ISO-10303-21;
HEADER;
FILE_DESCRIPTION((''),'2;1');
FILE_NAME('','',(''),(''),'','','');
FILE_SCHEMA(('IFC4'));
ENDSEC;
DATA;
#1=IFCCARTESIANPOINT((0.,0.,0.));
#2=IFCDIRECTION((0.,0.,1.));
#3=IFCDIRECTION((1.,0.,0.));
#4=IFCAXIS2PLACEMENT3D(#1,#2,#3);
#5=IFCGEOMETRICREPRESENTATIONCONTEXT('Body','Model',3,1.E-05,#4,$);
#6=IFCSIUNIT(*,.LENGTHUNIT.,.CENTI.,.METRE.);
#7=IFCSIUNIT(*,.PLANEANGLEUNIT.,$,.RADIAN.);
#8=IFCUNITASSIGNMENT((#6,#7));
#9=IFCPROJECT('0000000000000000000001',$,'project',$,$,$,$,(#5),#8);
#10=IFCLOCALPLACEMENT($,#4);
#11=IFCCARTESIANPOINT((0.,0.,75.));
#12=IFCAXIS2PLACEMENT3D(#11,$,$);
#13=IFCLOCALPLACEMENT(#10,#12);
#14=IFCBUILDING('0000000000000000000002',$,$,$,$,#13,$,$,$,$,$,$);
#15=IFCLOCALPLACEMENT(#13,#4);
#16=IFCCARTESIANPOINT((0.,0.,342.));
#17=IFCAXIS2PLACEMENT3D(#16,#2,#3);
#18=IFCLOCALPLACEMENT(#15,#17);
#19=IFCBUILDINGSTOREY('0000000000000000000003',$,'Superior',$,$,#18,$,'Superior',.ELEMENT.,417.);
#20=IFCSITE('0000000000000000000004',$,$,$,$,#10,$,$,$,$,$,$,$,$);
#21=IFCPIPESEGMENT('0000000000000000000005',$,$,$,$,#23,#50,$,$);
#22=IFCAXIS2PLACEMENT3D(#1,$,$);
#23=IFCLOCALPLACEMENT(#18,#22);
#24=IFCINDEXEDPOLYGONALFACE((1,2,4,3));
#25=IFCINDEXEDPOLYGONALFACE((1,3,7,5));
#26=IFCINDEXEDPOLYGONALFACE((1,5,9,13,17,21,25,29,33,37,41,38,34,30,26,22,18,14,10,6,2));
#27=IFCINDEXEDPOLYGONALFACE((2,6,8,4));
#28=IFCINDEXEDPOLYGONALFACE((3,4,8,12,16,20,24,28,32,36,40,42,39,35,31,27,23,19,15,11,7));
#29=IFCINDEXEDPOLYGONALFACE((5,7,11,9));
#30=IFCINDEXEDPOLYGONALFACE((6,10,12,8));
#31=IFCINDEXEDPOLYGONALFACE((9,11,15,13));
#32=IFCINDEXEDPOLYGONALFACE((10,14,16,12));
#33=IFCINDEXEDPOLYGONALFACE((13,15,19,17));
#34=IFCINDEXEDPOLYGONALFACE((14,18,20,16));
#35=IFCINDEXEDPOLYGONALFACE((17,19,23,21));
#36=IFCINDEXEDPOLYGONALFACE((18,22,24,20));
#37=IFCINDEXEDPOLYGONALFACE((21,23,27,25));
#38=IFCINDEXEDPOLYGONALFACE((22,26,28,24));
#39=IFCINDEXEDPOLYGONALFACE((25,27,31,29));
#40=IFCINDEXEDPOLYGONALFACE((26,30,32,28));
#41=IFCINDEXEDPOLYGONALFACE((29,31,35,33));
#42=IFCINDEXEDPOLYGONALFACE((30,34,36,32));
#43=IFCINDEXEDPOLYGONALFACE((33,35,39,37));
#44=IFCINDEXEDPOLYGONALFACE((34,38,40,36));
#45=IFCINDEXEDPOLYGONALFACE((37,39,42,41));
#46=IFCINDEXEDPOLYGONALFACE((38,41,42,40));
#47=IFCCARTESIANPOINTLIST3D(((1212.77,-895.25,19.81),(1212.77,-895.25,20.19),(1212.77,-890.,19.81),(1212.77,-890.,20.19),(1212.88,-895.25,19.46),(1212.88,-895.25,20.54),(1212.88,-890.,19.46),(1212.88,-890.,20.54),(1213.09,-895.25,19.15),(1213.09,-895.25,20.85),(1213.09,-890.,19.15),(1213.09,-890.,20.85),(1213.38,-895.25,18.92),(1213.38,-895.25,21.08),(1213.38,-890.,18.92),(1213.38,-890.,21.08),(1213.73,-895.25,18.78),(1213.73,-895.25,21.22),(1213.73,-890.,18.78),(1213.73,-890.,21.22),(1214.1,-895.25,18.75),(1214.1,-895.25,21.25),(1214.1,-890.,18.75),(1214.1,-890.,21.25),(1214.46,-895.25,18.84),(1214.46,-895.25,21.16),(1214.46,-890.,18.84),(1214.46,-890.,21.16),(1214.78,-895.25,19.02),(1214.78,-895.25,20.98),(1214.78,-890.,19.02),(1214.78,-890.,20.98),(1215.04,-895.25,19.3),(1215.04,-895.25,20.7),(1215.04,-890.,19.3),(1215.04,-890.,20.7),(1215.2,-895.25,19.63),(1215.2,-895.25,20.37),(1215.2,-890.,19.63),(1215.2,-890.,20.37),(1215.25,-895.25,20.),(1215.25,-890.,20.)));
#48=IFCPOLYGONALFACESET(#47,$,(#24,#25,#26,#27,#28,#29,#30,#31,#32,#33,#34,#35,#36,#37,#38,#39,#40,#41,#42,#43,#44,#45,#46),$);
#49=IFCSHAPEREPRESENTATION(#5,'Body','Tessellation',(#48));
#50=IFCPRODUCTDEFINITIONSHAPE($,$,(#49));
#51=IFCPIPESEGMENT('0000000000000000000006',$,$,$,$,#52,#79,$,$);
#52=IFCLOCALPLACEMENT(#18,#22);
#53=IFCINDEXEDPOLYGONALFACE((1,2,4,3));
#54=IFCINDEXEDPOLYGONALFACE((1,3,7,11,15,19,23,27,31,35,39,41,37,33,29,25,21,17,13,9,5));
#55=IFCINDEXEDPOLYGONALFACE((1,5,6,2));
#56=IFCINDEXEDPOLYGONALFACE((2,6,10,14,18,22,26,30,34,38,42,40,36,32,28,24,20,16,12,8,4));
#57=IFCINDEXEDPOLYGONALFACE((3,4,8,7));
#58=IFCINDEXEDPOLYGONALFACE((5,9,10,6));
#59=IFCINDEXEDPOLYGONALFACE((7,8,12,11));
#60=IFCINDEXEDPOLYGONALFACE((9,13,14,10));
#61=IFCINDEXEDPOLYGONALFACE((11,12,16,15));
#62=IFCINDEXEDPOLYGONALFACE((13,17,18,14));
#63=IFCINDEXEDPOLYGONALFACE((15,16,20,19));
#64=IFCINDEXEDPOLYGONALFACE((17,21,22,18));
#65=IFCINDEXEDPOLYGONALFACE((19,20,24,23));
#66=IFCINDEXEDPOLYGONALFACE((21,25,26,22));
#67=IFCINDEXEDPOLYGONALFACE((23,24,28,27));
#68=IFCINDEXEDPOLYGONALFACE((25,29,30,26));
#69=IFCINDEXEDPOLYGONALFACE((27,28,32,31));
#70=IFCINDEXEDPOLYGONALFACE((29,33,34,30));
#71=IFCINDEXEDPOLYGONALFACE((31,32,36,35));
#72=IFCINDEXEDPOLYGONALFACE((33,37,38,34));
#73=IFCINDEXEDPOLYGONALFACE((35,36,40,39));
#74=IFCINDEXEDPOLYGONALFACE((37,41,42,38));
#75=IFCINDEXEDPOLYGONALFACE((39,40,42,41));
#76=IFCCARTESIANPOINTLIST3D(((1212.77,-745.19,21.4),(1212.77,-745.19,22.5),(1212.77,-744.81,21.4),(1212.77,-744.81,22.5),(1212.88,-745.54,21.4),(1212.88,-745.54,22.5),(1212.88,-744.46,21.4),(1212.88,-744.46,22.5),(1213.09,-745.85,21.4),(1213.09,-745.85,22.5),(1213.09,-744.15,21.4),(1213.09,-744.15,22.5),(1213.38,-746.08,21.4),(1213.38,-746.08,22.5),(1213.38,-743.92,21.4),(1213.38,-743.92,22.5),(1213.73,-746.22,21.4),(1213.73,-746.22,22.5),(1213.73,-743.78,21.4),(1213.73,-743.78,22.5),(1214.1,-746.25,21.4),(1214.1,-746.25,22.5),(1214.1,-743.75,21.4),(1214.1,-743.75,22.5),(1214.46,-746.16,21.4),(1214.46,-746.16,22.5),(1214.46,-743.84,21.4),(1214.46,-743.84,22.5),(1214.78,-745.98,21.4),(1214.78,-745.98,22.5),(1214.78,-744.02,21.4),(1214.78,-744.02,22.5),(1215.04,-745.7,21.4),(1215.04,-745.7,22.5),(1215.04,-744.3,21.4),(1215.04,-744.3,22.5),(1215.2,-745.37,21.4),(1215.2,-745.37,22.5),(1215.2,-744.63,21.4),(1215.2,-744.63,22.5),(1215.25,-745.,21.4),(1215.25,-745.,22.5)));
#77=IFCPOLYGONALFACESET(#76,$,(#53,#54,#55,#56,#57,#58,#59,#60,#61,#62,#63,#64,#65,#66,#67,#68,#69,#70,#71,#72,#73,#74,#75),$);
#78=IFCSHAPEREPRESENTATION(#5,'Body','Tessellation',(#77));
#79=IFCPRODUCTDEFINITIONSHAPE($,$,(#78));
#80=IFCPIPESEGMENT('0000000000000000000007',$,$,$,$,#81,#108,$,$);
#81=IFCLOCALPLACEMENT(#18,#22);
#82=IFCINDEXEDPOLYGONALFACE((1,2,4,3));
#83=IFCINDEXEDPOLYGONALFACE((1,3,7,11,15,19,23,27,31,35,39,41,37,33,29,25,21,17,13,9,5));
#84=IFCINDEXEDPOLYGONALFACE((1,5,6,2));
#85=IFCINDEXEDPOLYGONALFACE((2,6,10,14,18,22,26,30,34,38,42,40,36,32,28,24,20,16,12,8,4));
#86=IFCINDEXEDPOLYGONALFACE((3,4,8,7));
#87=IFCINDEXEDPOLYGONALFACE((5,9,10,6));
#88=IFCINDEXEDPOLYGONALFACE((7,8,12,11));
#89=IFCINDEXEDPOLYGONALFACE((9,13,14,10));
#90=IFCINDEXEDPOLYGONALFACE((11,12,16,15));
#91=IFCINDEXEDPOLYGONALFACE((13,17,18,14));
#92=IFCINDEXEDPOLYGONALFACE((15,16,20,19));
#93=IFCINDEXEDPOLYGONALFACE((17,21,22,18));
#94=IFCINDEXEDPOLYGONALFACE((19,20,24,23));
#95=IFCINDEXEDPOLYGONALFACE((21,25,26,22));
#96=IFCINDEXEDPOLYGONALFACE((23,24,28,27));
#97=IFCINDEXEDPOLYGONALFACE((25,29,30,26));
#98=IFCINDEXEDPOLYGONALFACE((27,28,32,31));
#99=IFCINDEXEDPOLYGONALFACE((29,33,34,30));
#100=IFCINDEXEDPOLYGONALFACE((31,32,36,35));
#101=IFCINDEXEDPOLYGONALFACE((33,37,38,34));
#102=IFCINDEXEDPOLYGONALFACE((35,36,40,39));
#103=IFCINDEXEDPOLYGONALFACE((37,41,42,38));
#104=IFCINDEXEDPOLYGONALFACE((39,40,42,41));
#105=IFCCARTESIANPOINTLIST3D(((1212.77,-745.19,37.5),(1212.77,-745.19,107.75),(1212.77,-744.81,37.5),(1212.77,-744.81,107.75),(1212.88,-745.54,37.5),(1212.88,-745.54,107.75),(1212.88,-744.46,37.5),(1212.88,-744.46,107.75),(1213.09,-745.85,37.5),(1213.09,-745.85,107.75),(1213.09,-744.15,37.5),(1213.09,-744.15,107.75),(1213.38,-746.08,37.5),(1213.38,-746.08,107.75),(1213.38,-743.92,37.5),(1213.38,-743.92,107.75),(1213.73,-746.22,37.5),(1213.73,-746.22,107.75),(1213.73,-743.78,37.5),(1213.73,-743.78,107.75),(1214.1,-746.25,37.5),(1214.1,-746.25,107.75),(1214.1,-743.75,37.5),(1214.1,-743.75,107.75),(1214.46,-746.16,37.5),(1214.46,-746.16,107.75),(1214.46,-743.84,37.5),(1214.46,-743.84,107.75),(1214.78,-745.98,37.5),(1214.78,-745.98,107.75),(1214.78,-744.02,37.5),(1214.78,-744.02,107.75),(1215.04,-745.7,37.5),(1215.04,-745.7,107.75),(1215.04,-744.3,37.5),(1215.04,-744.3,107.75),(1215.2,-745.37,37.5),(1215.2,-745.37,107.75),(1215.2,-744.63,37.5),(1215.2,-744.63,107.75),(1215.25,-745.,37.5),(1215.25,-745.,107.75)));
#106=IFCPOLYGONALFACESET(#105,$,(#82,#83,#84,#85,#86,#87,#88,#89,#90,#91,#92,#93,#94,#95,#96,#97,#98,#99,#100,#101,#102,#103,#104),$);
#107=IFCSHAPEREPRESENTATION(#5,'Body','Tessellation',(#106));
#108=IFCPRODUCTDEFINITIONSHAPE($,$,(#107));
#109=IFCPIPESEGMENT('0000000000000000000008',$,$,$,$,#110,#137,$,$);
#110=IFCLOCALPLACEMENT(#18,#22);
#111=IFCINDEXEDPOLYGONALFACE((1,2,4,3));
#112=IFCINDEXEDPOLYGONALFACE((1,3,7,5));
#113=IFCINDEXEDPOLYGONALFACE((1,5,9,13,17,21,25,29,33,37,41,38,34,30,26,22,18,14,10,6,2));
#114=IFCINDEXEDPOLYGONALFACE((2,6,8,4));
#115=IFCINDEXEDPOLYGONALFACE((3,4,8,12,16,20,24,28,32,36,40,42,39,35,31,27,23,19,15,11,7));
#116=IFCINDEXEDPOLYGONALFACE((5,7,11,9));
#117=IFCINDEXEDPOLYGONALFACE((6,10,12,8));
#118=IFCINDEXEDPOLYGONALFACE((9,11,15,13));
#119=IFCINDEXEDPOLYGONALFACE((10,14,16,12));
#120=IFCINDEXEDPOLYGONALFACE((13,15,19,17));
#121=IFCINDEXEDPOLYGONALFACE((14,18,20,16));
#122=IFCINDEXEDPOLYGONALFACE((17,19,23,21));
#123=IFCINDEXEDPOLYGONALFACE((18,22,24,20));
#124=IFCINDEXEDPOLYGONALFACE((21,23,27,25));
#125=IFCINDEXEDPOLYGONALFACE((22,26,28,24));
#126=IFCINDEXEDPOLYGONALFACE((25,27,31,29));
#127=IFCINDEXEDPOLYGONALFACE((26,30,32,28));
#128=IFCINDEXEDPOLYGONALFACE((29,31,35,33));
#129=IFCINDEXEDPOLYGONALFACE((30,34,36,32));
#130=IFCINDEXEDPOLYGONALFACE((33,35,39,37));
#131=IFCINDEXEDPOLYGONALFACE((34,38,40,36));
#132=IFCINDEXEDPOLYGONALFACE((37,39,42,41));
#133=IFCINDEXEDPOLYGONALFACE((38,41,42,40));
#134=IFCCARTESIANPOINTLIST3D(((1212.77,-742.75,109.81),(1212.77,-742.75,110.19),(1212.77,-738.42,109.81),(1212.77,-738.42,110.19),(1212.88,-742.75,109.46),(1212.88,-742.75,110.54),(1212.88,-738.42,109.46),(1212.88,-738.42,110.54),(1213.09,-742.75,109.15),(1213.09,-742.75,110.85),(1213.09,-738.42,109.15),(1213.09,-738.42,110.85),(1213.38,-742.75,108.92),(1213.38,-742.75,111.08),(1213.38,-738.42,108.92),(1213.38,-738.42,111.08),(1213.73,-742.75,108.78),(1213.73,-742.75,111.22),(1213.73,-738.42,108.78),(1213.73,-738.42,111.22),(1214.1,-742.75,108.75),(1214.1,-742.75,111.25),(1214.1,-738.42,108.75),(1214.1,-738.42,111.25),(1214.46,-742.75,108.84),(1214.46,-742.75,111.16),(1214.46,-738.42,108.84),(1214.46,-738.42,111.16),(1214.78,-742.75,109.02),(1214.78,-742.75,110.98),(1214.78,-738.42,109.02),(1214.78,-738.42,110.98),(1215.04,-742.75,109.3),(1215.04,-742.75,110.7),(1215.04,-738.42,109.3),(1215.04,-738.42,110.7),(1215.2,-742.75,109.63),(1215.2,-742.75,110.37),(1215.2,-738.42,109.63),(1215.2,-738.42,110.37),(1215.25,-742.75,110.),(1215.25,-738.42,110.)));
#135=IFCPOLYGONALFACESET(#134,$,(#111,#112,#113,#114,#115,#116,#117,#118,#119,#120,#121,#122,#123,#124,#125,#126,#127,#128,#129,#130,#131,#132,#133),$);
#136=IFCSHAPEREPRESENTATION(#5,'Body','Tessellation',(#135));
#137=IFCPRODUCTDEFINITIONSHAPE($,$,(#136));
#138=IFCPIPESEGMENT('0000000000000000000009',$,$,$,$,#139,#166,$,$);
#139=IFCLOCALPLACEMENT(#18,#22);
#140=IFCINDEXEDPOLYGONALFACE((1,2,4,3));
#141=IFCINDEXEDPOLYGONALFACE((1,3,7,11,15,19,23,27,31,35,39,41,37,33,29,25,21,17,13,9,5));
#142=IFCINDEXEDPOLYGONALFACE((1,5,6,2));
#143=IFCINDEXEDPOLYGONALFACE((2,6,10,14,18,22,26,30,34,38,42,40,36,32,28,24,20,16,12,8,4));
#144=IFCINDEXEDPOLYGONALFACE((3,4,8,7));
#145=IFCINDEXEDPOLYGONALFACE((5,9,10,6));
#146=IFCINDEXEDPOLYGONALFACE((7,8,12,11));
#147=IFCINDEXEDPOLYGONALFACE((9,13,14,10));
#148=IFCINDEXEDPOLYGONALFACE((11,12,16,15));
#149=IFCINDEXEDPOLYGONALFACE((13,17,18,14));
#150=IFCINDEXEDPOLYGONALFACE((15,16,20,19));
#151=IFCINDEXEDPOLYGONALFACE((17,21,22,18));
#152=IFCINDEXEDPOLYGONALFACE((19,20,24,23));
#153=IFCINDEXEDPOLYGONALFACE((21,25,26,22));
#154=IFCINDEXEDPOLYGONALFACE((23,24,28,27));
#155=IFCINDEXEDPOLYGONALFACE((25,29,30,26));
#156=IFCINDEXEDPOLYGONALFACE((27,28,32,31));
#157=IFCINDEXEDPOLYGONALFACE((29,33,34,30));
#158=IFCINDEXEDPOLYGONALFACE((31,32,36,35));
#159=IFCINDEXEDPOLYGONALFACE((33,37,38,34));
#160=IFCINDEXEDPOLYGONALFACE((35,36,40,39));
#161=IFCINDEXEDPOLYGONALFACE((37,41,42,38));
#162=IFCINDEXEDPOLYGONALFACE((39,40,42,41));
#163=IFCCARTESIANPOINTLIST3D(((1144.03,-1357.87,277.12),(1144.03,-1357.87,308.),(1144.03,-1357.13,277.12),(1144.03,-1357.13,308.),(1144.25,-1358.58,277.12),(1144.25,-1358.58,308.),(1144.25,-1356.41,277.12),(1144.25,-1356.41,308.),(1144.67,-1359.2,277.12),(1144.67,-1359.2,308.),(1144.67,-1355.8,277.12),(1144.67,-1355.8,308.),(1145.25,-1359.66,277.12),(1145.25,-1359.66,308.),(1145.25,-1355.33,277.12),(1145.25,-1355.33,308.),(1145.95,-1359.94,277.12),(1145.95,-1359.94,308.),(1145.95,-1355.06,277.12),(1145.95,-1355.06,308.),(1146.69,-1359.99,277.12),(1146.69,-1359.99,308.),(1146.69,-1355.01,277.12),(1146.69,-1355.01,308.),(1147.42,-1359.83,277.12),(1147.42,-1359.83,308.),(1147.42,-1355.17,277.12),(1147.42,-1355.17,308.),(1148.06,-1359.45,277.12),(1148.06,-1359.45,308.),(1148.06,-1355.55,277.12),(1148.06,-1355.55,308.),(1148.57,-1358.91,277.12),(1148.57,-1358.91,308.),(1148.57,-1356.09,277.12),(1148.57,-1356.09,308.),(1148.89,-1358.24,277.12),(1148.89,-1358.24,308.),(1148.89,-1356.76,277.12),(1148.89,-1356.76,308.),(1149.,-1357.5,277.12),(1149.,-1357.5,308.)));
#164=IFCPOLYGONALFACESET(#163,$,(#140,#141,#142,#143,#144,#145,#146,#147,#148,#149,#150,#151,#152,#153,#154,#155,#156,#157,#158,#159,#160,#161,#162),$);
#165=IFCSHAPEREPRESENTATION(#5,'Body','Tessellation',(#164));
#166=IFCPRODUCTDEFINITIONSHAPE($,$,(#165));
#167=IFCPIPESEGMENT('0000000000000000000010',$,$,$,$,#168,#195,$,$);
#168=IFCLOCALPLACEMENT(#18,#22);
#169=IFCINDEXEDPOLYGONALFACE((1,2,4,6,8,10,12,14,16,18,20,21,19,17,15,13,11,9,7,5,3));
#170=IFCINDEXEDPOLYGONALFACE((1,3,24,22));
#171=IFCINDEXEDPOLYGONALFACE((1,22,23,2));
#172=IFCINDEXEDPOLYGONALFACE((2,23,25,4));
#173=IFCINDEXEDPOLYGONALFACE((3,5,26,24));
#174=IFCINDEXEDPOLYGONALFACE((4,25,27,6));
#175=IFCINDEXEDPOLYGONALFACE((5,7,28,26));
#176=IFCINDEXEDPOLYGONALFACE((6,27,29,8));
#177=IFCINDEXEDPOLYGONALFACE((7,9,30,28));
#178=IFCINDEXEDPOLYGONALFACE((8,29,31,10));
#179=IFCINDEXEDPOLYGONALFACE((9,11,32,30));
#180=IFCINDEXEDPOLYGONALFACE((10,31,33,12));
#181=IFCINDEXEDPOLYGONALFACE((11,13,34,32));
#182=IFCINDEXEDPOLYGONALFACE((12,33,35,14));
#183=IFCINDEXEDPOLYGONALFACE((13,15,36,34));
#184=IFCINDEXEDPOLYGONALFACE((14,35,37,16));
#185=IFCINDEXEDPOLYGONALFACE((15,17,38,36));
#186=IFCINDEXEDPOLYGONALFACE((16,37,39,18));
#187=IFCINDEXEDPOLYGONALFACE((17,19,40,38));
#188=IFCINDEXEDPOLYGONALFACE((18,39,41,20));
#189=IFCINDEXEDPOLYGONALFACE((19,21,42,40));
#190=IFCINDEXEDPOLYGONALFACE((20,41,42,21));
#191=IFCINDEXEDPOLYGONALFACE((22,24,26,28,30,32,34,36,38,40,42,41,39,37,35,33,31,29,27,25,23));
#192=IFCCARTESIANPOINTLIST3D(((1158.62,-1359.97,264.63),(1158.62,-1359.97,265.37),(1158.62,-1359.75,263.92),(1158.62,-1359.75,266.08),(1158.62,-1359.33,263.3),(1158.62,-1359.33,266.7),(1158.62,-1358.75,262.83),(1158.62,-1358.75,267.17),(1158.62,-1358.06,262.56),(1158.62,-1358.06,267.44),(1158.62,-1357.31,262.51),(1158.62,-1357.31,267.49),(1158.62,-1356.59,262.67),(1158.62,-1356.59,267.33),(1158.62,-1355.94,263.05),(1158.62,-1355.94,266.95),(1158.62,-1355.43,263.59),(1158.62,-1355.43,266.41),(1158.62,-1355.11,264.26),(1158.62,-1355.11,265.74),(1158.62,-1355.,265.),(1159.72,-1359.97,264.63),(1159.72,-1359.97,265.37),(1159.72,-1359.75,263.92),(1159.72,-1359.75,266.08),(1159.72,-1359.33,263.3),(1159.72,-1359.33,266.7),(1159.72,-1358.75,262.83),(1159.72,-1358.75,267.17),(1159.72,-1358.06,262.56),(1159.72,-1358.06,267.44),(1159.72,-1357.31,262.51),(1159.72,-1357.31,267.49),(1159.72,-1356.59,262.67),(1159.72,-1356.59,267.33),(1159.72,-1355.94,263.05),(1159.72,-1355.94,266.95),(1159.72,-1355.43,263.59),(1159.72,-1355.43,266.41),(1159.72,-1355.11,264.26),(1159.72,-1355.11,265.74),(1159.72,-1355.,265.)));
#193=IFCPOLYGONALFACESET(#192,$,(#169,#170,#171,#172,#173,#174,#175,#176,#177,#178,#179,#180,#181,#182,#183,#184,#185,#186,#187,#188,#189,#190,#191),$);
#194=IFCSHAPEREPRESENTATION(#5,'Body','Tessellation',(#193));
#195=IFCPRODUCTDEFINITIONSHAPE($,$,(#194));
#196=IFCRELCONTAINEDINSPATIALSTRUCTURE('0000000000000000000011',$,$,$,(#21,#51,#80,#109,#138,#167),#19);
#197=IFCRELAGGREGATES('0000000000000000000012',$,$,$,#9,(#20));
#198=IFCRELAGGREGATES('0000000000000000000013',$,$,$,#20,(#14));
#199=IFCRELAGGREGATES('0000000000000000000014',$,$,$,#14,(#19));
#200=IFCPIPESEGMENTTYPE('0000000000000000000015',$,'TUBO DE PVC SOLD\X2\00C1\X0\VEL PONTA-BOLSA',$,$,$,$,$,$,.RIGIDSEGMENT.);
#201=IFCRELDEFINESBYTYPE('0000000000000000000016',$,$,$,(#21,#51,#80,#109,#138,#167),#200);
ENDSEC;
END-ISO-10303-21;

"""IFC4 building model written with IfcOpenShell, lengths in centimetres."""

from ifc_helpers import new_model, si_unit, frame, origin_with_axes, origin_2d_with_axis, place, context, project, spatial, circle, extrude, type_object, element, save


model = new_model("IFC4")

# Units and contexts
model_context = context("Model", 3, precision=1e-05, world=origin_with_axes(), identifier="Body")
ifc_project = project(units=[si_unit("LENGTHUNIT", "METRE", prefix="CENTI"), si_unit("PLANEANGLEUNIT", "RADIAN")], contexts=[model_context])

# Site, building, storey
site_placement = place(None, origin_with_axes())
site = spatial("IfcSite", under=ifc_project, at=site_placement)
building_placement = place(site_placement, frame((0.0, 0.0, 75.0)))
building = spatial("IfcBuilding", under=site, at=building_placement)
placement = place(building_placement, origin_with_axes())
storey_placement = place(placement, frame((0.0, 0.0, 342.0), z_axis=(0.0, 0.0, 1.0), x_axis=(1.0, 0.0, 0.0)))
storey = spatial("IfcBuildingStorey", under=building, at=storey_placement, Name="Superior", LongName="Superior", CompositionType="ELEMENT", Elevation=417.0)

# Pipe segments
pipe_segment_type_1 = type_object("IfcPipeSegmentType", Name="TUBO DE PVC SOLDÁVEL PONTA-BOLSA", PredefinedType="RIGIDSEGMENT")
pipe_segment_1_placement = place(storey_placement, frame((1214.0, -892.62, 21.25), z_axis=(0.0, 0.0, 1.0), x_axis=(1.0, 0.0, 0.0)))
element("IfcPipeSegment", 1, at=pipe_segment_1_placement, inside=storey, type_object=pipe_segment_type_1, context=model_context, shape_type="SolidModel", body=[
    extrude(circle(Radius=1.25, at=origin_2d_with_axis()), frame((0.0, 2.62, -1.25), z_axis=(0.0, -1.0, 0.0), x_axis=(1.0, 0.0, 0.0)), (0.0, 0.0, 1.0), 5.25),
])
pipe_segment_2_placement = place(storey_placement, frame((1214.0, -745.0, 22.5), z_axis=(0.0, 0.0, 1.0), x_axis=(1.0, 0.0, 0.0)))
element("IfcPipeSegment", 2, at=pipe_segment_2_placement, inside=storey, type_object=pipe_segment_type_1, context=model_context, shape_type="SolidModel", body=[
    extrude(circle(Radius=1.25, at=origin_2d_with_axis()), frame((0.0, 0.0, 0.0), z_axis=(0.0, 0.0, -1.0), x_axis=(1.0, 0.0, 0.0)), (0.0, 0.0, 1.0), 1.1),
])
pipe_segment_3_placement = place(storey_placement, frame((1214.0, -745.0, 107.75), z_axis=(0.0, 0.0, 1.0), x_axis=(1.0, 0.0, 0.0)))
element("IfcPipeSegment", 3, at=pipe_segment_3_placement, inside=storey, type_object=pipe_segment_type_1, context=model_context, shape_type="SolidModel", body=[
    extrude(circle(Radius=1.25, at=origin_2d_with_axis()), frame((0.0, 0.0, 0.0), z_axis=(0.0, 0.0, -1.0), x_axis=(1.0, 0.0, 0.0)), (0.0, 0.0, 1.0), 70.25),
])
pipe_segment_4_placement = place(storey_placement, frame((1214.0, -740.59, 111.25), z_axis=(0.0, 0.0, 1.0), x_axis=(1.0, 0.0, 0.0)))
element("IfcPipeSegment", 4, at=pipe_segment_4_placement, inside=storey, type_object=pipe_segment_type_1, context=model_context, shape_type="SolidModel", body=[
    extrude(circle(Radius=1.25, at=origin_2d_with_axis()), frame((0.0, -2.16, -1.25), z_axis=(0.0, 1.0, 0.0), x_axis=(1.0, 0.0, 0.0)), (0.0, 0.0, 1.0), 4.33),
])
pipe_segment_5_placement = place(storey_placement, frame((1146.5, -1357.5, 308.0), z_axis=(0.0, 0.0, 1.0), x_axis=(1.0, 0.0, 0.0)))
element("IfcPipeSegment", 5, at=pipe_segment_5_placement, inside=storey, type_object=pipe_segment_type_1, context=model_context, shape_type="SolidModel", body=[
    extrude(circle(Radius=2.5, at=origin_2d_with_axis()), frame((0.0, 0.0, 0.0), z_axis=(0.0, 0.0, -1.0), x_axis=(1.0, 0.0, 0.0)), (0.0, 0.0, 1.0), 30.88),
])
pipe_segment_6_placement = place(storey_placement, frame((1159.17, -1357.5, 267.5), z_axis=(0.0, 0.0, 1.0), x_axis=(1.0, 0.0, 0.0)))
element("IfcPipeSegment", 6, at=pipe_segment_6_placement, inside=storey, type_object=pipe_segment_type_1, context=model_context, shape_type="SolidModel", body=[
    extrude(circle(Radius=2.5, at=origin_2d_with_axis()), frame((-0.55, 0.0, -2.5), z_axis=(1.0, 0.0, 0.0), x_axis=(0.0, 1.0, 0.0)), (0.0, 0.0, 1.0), 1.1),
])

save(model, "model.ifc")
